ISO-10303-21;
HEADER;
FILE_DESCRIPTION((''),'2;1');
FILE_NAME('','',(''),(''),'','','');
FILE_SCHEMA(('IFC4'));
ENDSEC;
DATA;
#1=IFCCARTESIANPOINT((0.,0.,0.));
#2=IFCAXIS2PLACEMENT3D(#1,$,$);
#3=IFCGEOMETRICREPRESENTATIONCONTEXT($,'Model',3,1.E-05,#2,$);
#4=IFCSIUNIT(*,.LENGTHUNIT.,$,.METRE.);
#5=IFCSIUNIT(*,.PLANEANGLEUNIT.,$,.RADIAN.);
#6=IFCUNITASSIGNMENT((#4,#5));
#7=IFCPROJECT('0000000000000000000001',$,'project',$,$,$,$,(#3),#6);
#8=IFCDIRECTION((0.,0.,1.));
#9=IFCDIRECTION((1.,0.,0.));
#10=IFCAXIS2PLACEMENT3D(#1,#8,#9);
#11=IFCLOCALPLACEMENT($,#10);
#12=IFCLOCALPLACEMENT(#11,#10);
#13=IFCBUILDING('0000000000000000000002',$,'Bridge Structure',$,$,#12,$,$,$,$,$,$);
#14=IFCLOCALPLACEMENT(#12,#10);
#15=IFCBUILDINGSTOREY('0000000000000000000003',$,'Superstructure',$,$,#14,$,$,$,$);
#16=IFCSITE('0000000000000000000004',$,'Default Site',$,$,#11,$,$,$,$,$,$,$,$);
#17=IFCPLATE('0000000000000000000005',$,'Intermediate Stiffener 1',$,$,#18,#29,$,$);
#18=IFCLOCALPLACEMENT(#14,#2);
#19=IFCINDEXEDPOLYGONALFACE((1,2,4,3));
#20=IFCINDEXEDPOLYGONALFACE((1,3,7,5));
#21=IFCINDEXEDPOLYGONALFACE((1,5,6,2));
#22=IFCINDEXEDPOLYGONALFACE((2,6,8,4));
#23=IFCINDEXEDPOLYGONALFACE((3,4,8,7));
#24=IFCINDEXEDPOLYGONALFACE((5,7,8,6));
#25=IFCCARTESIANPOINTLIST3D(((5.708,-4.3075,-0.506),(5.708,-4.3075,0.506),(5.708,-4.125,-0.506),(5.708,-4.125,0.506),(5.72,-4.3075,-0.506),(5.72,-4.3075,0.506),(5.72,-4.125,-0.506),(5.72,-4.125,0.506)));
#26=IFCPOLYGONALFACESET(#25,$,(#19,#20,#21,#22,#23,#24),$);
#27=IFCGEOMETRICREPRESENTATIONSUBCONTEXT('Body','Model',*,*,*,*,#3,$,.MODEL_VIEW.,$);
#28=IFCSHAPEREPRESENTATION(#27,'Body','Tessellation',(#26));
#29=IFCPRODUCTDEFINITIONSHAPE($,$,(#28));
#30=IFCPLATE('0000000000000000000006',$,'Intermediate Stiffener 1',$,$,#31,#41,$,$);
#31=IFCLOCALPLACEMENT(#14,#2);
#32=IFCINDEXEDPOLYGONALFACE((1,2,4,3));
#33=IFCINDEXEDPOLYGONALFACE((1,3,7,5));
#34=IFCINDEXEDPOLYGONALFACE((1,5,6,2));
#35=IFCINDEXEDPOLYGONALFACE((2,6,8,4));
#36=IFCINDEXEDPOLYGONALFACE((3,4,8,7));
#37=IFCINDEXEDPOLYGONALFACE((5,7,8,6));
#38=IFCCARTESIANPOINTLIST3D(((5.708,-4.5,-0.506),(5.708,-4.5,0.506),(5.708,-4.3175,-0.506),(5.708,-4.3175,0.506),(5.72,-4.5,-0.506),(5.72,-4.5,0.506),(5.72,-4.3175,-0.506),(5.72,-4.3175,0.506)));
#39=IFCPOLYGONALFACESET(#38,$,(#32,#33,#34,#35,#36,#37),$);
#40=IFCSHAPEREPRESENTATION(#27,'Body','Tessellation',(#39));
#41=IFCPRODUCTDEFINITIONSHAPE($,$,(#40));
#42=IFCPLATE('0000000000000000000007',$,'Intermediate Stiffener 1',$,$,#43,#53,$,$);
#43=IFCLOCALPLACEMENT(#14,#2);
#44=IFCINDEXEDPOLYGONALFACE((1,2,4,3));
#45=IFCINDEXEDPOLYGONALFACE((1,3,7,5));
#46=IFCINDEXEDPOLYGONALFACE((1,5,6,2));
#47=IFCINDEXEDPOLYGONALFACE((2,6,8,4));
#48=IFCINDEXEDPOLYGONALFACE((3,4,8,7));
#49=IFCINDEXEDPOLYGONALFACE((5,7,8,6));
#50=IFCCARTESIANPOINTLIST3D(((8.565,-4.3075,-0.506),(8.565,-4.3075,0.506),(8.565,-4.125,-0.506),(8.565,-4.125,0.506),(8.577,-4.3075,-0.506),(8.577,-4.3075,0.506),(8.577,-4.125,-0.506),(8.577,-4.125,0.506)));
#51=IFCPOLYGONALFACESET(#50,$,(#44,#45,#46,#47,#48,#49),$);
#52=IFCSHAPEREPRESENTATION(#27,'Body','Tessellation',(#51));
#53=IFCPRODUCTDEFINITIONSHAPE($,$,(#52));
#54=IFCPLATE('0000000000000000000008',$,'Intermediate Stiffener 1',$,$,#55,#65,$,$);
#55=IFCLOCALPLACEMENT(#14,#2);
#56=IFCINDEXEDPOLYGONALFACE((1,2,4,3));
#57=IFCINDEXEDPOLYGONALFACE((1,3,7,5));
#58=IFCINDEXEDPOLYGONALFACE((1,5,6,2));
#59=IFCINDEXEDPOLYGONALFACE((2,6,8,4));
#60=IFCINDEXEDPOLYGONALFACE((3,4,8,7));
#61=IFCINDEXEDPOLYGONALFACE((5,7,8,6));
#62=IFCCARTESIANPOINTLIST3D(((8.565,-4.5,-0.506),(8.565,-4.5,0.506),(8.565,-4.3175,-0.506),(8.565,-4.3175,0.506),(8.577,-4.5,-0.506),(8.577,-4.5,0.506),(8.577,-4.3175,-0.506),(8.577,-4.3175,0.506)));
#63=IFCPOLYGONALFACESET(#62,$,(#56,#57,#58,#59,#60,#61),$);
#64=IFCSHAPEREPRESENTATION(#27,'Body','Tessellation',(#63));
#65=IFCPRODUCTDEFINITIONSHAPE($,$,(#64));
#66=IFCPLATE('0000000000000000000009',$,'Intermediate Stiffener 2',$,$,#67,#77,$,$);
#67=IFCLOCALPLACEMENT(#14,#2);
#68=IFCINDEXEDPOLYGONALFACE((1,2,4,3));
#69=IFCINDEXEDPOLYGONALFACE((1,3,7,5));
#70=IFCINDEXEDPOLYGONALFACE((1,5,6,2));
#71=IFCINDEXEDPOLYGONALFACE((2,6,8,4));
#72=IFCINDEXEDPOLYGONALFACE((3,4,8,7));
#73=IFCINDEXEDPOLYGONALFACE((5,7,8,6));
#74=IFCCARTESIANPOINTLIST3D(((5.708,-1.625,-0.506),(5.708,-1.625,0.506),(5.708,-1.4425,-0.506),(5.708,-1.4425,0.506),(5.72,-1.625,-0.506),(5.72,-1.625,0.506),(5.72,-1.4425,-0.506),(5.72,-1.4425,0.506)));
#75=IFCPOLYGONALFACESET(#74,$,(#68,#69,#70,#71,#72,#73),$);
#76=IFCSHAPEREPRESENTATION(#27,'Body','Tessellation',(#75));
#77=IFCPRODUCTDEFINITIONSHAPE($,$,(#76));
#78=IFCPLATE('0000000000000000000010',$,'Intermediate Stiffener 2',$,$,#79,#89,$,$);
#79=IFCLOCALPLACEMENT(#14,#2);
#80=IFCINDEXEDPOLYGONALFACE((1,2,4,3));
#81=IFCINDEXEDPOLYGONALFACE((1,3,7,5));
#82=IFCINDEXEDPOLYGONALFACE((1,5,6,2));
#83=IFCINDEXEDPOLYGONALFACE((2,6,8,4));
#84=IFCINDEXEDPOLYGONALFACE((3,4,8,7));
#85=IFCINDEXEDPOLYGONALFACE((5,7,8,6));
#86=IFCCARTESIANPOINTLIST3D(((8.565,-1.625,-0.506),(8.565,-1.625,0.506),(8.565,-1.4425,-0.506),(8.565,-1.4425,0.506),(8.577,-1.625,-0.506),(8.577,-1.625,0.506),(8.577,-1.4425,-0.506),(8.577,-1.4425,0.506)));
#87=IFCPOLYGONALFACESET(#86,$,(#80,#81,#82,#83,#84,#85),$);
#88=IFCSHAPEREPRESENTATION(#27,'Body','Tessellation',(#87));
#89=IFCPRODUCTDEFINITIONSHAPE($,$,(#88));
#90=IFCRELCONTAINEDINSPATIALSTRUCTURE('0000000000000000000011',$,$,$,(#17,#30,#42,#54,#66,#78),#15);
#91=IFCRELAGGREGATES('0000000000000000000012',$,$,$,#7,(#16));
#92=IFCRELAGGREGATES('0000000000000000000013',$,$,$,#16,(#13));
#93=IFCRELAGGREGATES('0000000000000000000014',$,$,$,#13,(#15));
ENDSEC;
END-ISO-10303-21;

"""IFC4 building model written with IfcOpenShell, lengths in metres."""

from ifc_helpers import new_model, si_unit, frame, origin, origin_with_axes, origin_2d_with_axis, place, context, subcontext, project, spatial, rectangle, extrude, element, save


model = new_model("IFC4")

# Units and contexts
model_context = context("Model", 3, precision=1e-05, world=origin())
body_context = subcontext(model_context, "Body", "Model", "MODEL_VIEW")
ifc_project = project(units=[si_unit("LENGTHUNIT", "METRE"), si_unit("PLANEANGLEUNIT", "RADIAN")], contexts=[model_context])

# Site, building, storey
site_placement = place(None, origin_with_axes())
site = spatial("IfcSite", under=ifc_project, at=site_placement, Name="Default Site")
building_placement = place(site_placement, origin_with_axes())
building = spatial("IfcBuilding", under=site, at=building_placement, Name="Bridge Structure")
storey_placement = place(building_placement, origin_with_axes())
storey = spatial("IfcBuildingStorey", under=building, at=storey_placement, Name="Superstructure")

# Plates
for number, where, z_axis, x_axis, name in (
    (1, (5.714, -4.2163, -0.506), (0.0, 0.0, 1.0), (1.0, 0.0, 0.0), "Intermediate Stiffener 1"),
    (2, (5.714, -4.4088, -0.506), (0.0, 0.0, 1.0), (1.0, 0.0, 0.0), "Intermediate Stiffener 1"),
    (3, (8.571, -4.2163, -0.506), (0.0, 0.0, 1.0), (1.0, 0.0, 0.0), "Intermediate Stiffener 1"),
    (4, (8.571, -4.4088, -0.506), (0.0, 0.0, 1.0), (1.0, 0.0, 0.0), "Intermediate Stiffener 1"),
    (5, (5.714, -1.5337, -0.506), (0.0, 0.0, 1.0), (1.0, 0.0, 0.0), "Intermediate Stiffener 2"),
    (6, (8.571, -1.5337, -0.506), (0.0, 0.0, 1.0), (1.0, 0.0, 0.0), "Intermediate Stiffener 2"),
):
    element("IfcPlate", number, at=place(storey_placement, frame(where, z_axis=z_axis, x_axis=x_axis)), inside=storey, Name=name, context=body_context, shape_type="SweptSolid", body=[
        extrude(rectangle(XDim=0.012, YDim=0.1825, at=origin_2d_with_axis()), origin_with_axes(), (0.0, 0.0, 1.0), 1.012),
    ])

save(model, "model.ifc")
